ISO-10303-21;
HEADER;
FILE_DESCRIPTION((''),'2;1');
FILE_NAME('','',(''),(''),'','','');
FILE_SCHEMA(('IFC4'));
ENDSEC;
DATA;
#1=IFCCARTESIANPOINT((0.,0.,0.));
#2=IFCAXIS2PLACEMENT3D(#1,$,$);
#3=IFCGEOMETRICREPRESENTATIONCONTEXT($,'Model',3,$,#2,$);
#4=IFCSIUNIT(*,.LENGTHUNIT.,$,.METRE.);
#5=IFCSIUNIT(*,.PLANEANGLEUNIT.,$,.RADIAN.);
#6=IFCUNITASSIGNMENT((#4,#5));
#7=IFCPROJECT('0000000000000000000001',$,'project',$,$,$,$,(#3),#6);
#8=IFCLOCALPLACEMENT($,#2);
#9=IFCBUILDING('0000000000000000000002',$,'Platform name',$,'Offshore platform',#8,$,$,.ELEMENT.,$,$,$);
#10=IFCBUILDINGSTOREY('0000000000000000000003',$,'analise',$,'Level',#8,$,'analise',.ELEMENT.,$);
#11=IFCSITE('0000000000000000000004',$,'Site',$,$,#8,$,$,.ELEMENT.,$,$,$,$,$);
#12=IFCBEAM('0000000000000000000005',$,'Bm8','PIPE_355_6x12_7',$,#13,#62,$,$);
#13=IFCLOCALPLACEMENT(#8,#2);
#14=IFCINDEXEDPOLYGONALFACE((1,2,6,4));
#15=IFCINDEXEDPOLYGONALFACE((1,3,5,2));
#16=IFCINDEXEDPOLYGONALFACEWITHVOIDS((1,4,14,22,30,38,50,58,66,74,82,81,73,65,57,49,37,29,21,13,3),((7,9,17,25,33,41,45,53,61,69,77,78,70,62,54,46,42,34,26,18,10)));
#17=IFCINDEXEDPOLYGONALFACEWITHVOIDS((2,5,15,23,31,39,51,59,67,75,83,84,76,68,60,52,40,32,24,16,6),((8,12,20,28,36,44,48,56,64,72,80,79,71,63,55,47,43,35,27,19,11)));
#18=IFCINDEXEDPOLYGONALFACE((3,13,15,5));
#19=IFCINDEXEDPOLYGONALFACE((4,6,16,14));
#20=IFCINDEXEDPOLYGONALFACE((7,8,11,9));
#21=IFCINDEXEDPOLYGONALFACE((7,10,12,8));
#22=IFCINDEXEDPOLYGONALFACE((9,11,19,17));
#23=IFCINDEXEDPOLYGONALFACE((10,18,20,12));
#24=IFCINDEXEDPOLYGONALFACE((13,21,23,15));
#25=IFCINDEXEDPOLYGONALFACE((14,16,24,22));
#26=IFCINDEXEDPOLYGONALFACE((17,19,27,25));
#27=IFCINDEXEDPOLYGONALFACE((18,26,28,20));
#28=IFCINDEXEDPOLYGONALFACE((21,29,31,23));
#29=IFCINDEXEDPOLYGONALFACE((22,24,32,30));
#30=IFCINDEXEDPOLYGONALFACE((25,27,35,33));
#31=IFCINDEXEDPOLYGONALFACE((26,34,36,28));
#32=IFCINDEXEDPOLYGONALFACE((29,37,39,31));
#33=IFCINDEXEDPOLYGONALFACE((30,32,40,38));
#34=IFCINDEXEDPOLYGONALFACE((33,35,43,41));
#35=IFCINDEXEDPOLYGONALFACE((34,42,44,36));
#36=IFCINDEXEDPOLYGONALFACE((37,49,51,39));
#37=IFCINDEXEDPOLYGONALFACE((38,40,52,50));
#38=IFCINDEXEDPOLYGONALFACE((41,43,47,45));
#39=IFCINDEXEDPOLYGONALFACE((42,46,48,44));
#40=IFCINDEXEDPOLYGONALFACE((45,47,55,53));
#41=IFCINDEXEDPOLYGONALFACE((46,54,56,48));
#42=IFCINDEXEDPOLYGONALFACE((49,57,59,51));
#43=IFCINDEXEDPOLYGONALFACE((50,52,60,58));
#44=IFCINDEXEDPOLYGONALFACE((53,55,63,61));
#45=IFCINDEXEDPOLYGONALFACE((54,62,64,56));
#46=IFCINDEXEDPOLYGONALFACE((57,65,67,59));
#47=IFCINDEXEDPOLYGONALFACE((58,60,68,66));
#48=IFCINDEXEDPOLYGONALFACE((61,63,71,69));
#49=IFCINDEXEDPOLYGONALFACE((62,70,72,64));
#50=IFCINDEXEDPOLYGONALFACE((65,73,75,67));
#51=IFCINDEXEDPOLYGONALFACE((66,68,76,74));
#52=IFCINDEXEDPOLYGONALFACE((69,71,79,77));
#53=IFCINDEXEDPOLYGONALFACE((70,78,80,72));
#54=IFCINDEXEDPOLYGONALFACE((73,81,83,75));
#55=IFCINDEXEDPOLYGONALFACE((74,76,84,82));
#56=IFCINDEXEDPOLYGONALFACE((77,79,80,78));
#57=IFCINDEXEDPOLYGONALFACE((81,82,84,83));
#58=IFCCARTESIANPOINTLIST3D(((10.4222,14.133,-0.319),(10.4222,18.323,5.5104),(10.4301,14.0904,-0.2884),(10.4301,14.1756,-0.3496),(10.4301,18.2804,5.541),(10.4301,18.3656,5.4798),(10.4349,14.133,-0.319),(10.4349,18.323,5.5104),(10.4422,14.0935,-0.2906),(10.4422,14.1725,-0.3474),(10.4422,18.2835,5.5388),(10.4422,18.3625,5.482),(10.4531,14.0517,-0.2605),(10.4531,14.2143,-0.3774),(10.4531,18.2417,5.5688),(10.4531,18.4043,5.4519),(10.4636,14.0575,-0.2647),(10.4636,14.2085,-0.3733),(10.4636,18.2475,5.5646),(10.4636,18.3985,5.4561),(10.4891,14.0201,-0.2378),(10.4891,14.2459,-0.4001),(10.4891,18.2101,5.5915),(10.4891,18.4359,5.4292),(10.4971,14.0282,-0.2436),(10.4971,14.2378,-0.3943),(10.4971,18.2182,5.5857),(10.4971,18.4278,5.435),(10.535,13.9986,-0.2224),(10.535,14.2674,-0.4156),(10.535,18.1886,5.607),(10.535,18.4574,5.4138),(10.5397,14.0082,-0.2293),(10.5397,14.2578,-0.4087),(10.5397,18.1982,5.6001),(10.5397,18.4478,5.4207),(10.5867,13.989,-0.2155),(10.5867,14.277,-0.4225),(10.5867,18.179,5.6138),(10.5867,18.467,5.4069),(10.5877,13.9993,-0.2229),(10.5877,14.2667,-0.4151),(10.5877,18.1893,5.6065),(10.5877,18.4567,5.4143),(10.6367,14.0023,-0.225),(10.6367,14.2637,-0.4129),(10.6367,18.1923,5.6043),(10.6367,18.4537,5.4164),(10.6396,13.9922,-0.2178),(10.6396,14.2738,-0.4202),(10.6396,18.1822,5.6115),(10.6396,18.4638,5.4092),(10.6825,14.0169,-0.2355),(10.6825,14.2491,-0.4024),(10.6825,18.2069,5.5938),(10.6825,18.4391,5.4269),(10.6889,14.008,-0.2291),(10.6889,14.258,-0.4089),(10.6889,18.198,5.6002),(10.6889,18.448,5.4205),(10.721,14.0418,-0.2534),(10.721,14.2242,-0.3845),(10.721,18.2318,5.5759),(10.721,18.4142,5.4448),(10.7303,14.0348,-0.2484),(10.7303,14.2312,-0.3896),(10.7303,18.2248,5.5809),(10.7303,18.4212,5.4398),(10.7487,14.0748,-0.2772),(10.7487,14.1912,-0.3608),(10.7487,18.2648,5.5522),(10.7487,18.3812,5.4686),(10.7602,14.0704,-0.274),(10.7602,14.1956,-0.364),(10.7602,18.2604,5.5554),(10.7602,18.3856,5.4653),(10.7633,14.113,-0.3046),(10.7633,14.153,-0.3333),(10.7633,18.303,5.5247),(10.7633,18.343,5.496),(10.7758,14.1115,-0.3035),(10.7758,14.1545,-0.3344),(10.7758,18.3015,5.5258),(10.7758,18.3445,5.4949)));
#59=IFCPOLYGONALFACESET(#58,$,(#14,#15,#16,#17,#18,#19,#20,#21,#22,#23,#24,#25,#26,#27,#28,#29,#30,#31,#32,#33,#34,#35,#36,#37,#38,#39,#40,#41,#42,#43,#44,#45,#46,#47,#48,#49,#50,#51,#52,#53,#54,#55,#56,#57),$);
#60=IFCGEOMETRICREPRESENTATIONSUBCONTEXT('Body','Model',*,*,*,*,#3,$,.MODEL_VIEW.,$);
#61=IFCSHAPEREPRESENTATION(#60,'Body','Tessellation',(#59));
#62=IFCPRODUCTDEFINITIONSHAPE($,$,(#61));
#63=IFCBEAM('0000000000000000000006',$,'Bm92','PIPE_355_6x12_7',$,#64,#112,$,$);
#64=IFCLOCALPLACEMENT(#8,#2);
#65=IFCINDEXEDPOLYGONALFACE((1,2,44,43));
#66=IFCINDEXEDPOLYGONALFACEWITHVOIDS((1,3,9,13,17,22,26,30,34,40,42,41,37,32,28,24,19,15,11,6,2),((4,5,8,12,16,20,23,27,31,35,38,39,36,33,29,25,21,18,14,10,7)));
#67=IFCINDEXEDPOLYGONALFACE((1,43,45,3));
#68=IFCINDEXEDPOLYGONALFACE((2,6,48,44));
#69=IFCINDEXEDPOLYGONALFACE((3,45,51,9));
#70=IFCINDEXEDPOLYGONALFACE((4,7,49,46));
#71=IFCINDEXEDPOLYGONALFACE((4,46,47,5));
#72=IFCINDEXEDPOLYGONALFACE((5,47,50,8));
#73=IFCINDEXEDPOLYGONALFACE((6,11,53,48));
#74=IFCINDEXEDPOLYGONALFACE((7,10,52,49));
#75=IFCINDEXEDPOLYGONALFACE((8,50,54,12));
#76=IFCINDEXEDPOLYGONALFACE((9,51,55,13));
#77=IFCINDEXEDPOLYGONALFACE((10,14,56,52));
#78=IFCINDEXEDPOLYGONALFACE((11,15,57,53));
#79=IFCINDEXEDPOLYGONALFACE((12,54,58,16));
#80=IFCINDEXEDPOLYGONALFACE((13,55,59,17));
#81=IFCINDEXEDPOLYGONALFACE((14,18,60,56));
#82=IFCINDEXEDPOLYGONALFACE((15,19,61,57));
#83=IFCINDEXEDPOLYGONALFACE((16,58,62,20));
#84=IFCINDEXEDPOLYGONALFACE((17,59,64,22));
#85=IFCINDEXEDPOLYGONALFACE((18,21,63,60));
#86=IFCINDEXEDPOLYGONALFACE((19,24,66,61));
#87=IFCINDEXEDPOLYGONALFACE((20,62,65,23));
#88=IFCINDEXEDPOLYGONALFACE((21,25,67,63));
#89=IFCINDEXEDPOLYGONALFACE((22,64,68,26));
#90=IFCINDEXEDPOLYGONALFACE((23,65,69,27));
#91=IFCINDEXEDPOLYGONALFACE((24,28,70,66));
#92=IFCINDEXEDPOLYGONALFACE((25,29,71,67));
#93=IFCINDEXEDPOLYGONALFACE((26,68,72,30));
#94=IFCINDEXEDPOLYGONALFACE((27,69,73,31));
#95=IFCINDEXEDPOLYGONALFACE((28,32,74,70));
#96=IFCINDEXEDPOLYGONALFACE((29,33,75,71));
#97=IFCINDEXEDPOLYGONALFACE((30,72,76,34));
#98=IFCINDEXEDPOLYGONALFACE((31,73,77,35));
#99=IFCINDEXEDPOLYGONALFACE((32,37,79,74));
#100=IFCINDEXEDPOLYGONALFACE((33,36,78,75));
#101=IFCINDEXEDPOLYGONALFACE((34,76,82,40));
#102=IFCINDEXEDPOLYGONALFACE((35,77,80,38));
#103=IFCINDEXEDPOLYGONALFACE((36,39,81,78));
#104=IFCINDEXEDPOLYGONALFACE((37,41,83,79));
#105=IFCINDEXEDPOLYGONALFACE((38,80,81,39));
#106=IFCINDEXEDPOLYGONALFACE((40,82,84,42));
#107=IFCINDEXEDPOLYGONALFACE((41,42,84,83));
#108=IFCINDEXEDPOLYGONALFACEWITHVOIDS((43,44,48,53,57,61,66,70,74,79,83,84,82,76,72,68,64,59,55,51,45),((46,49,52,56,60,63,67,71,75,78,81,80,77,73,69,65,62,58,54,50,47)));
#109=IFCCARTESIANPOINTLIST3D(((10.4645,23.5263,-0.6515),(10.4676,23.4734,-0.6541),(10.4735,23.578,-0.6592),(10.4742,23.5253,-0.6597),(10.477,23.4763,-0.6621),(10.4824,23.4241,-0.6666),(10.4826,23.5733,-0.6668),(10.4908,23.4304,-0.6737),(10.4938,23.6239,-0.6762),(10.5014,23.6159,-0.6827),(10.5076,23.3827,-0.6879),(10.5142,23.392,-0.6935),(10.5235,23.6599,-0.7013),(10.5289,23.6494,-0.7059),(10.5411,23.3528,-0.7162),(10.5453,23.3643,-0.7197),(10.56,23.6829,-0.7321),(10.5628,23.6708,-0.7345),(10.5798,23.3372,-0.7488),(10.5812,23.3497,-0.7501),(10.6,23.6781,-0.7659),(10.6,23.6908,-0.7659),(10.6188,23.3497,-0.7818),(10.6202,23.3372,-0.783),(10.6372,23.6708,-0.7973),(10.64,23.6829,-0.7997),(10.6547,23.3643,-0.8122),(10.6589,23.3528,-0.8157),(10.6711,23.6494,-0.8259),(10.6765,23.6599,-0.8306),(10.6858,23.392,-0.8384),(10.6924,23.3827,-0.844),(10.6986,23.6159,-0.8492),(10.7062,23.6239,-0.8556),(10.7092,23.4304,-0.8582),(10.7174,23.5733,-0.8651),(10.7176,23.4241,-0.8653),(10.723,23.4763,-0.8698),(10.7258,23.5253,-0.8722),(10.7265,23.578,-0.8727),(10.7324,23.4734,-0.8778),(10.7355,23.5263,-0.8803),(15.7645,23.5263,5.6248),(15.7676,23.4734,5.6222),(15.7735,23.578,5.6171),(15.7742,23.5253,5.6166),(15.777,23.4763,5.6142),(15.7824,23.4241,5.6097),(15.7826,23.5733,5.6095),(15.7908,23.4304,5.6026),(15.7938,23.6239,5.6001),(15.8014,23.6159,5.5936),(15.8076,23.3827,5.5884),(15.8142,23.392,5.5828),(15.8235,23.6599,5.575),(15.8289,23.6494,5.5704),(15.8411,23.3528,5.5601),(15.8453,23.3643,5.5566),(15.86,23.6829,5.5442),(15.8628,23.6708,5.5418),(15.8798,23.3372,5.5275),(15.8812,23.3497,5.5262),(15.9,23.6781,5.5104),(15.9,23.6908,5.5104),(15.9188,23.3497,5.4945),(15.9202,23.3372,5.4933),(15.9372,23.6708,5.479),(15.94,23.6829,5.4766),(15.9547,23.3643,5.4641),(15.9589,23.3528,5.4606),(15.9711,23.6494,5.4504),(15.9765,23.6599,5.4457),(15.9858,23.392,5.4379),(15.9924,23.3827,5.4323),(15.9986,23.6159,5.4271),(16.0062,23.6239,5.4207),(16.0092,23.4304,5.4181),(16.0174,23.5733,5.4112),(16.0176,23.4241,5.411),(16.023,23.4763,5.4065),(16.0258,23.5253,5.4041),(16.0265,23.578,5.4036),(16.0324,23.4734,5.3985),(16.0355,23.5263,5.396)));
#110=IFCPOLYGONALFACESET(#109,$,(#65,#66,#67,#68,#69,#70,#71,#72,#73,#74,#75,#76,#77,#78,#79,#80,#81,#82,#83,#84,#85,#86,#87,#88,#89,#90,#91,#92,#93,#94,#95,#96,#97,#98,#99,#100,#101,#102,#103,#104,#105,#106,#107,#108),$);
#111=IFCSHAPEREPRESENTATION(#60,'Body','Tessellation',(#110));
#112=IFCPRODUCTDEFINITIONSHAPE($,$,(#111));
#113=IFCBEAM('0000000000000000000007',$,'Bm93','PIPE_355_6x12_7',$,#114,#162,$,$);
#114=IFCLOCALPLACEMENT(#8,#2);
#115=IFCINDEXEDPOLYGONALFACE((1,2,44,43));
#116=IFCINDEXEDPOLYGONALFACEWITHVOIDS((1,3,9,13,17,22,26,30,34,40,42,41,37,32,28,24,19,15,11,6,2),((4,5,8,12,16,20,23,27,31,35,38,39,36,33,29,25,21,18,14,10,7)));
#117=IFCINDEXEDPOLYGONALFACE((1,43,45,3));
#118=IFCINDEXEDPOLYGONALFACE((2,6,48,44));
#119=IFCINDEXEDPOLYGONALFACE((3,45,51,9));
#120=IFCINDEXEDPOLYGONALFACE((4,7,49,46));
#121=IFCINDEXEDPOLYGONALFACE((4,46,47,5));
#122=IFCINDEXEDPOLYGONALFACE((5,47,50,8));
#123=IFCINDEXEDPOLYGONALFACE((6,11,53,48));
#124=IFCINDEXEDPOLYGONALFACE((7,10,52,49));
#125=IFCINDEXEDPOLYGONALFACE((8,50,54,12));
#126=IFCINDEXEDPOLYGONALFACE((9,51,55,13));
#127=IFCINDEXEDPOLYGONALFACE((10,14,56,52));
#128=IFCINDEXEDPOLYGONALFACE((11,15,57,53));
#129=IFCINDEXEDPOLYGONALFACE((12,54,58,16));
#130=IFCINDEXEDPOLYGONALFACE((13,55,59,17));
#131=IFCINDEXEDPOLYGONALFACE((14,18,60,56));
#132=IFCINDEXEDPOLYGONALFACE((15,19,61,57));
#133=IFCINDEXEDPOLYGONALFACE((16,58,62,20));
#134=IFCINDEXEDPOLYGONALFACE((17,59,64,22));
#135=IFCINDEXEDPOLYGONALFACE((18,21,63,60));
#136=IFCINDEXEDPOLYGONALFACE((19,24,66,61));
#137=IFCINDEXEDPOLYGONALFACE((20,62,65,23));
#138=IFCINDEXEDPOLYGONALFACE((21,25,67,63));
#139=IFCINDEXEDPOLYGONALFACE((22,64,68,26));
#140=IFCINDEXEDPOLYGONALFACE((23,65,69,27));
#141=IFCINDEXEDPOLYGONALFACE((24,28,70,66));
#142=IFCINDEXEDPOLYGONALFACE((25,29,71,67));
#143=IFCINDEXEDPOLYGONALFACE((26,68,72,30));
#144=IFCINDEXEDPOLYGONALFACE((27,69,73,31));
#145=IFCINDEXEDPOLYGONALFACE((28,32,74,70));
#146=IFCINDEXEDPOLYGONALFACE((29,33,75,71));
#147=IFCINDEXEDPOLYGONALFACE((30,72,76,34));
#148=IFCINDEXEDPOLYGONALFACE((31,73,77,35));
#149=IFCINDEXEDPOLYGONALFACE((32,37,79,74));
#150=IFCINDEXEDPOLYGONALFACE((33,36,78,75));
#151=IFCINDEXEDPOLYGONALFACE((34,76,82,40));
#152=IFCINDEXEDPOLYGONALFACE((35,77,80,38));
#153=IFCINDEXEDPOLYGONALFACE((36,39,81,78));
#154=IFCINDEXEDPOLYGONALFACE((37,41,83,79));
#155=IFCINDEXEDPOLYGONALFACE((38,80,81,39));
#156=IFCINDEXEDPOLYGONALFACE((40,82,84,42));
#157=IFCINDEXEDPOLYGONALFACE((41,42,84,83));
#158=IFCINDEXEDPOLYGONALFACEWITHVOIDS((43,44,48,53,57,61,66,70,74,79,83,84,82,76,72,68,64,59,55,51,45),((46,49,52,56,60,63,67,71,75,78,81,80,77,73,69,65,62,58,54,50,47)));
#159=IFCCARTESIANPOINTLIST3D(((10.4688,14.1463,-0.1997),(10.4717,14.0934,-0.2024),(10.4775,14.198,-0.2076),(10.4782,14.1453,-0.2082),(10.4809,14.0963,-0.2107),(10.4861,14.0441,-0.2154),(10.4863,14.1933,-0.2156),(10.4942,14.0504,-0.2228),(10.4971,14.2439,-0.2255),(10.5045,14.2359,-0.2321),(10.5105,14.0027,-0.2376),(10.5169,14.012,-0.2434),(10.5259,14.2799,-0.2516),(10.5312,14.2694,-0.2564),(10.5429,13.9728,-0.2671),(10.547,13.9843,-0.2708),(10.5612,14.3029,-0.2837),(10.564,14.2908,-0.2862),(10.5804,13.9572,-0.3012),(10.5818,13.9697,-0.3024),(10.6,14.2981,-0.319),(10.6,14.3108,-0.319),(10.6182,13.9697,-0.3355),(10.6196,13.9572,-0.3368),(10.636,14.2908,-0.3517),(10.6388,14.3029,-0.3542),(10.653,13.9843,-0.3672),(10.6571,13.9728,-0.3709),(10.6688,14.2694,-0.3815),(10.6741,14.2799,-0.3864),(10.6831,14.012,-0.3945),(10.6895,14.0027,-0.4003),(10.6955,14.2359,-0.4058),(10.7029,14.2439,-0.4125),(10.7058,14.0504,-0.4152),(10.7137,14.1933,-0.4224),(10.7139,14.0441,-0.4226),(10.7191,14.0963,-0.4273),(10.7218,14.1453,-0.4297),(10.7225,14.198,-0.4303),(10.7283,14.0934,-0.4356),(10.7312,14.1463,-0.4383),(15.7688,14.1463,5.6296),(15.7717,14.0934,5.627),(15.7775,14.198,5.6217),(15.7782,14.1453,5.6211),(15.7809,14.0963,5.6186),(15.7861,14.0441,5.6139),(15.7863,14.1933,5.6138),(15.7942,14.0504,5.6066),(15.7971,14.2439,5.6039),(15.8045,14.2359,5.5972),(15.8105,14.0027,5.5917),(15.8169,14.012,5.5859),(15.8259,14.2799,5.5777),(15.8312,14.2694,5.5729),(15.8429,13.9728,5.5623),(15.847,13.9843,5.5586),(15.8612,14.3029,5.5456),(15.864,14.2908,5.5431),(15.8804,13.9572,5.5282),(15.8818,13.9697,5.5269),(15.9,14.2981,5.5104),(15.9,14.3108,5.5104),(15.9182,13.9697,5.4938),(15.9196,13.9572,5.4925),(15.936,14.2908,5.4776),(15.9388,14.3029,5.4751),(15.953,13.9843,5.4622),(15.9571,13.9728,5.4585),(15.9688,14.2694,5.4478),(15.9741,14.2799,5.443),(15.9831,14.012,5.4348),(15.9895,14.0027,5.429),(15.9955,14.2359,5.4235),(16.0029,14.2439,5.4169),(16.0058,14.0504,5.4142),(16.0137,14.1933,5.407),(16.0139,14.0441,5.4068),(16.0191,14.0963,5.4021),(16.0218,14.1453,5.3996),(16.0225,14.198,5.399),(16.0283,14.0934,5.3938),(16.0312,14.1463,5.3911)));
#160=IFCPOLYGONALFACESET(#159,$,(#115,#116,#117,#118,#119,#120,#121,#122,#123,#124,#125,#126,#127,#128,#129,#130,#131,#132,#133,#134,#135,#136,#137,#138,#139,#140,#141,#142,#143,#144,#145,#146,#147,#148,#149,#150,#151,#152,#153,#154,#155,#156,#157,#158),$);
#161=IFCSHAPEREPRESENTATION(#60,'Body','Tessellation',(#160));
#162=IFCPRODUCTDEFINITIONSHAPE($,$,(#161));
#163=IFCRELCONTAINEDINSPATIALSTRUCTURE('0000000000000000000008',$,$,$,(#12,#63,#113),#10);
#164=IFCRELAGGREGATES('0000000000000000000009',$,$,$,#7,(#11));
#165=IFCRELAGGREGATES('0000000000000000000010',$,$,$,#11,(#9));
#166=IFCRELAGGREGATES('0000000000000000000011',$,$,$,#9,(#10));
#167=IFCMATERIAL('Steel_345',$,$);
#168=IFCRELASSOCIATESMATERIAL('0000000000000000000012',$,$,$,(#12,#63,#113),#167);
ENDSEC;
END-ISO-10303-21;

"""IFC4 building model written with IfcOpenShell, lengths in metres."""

from ifc_helpers import new_model, si_unit, frame, origin, origin_2d, place, context, subcontext, project, spatial, hollow_circle, extrude, source, transform, mapped, material, element, save


model = new_model("IFC4")

# Units and contexts
model_context = context("Model", 3, world=origin())
body_context = subcontext(model_context, "Body", "Model", "MODEL_VIEW")
ifc_project = project(units=[si_unit("LENGTHUNIT", "METRE"), si_unit("PLANEANGLEUNIT", "RADIAN")], contexts=[model_context])

# Site, building, storey
placement_1 = place(None, origin())
site = spatial("IfcSite", under=ifc_project, at=placement_1, Name="Site", CompositionType="ELEMENT")
building = spatial("IfcBuilding", under=site, at=placement_1, Name="Platform name", ObjectType="Offshore platform", CompositionType="ELEMENT")
storey = spatial("IfcBuildingStorey", under=building, at=placement_1, Name="analise", ObjectType="Level", LongName="analise", CompositionType="ELEMENT")

# Beams
ifc_material_1 = material(Name="Steel_345")
shared_shape_1 = source(origin(), body_context, "Body", "SweptSolid", [
    extrude(hollow_circle(Radius=0.1778, WallThickness=0.0127, at=origin_2d()), frame((0.0, 0.0, 0.0), z_axis=(0.0, 0.583651, 0.812005), x_axis=(-1.0, 0.0, 0.0)), (0.0, 0.0, 1.0), 7.179),
])
placement_2 = place(None, origin())
placement_3 = place(placement_2, origin())
placement_4 = place(placement_3, origin())
beam_1_placement = place(placement_4, frame((10.6, 14.133, -0.319)))
element("IfcBeam", 1, at=beam_1_placement, inside=storey, material=ifc_material_1, Name="Bm8", Description="PIPE_355_6x12_7", context=body_context, shape_type="MappedRepresentation", body=[
    mapped(shared_shape_1, transform((0.0, 0.0, 0.0), scale=1.0)),
])
shared_shape_2 = source(origin(), body_context, "Body", "SweptSolid", [
    extrude(hollow_circle(Radius=0.1778, WallThickness=0.0127, at=origin_2d()), frame((0.0, 0.0, 0.0), z_axis=(0.645182, 0.0, 0.764029), x_axis=(0.0, 1.0, 0.0)), (0.0, 0.0, 1.0), 8.2147),
])
placement_5 = place(None, origin())
placement_6 = place(placement_5, origin())
placement_7 = place(placement_6, origin())
beam_2_placement = place(placement_7, frame((10.6, 23.513, -0.7659)))
element("IfcBeam", 2, at=beam_2_placement, inside=storey, material=ifc_material_1, Name="Bm92", Description="PIPE_355_6x12_7", context=body_context, shape_type="MappedRepresentation", body=[
    mapped(shared_shape_2, transform((0.0, 0.0, 0.0), scale=1.0)),
])
shared_shape_3 = source(origin(), body_context, "Body", "SweptSolid", [
    extrude(hollow_circle(Radius=0.1778, WallThickness=0.0127, at=origin_2d()), frame((0.0, 0.0, 0.0), z_axis=(0.672714, 0.0, 0.739903), x_axis=(0.0, 1.0, 0.0)), (0.0, 0.0, 1.0), 7.8785),
])
placement_8 = place(None, origin())
placement_9 = place(placement_8, origin())
placement_10 = place(placement_9, origin())
beam_3_placement = place(placement_10, frame((10.6, 14.133, -0.319)))
element("IfcBeam", 3, at=beam_3_placement, inside=storey, material=ifc_material_1, Name="Bm93", Description="PIPE_355_6x12_7", context=body_context, shape_type="MappedRepresentation", body=[
    mapped(shared_shape_3, transform((0.0, 0.0, 0.0), scale=1.0)),
])

save(model, "model.ifc")
